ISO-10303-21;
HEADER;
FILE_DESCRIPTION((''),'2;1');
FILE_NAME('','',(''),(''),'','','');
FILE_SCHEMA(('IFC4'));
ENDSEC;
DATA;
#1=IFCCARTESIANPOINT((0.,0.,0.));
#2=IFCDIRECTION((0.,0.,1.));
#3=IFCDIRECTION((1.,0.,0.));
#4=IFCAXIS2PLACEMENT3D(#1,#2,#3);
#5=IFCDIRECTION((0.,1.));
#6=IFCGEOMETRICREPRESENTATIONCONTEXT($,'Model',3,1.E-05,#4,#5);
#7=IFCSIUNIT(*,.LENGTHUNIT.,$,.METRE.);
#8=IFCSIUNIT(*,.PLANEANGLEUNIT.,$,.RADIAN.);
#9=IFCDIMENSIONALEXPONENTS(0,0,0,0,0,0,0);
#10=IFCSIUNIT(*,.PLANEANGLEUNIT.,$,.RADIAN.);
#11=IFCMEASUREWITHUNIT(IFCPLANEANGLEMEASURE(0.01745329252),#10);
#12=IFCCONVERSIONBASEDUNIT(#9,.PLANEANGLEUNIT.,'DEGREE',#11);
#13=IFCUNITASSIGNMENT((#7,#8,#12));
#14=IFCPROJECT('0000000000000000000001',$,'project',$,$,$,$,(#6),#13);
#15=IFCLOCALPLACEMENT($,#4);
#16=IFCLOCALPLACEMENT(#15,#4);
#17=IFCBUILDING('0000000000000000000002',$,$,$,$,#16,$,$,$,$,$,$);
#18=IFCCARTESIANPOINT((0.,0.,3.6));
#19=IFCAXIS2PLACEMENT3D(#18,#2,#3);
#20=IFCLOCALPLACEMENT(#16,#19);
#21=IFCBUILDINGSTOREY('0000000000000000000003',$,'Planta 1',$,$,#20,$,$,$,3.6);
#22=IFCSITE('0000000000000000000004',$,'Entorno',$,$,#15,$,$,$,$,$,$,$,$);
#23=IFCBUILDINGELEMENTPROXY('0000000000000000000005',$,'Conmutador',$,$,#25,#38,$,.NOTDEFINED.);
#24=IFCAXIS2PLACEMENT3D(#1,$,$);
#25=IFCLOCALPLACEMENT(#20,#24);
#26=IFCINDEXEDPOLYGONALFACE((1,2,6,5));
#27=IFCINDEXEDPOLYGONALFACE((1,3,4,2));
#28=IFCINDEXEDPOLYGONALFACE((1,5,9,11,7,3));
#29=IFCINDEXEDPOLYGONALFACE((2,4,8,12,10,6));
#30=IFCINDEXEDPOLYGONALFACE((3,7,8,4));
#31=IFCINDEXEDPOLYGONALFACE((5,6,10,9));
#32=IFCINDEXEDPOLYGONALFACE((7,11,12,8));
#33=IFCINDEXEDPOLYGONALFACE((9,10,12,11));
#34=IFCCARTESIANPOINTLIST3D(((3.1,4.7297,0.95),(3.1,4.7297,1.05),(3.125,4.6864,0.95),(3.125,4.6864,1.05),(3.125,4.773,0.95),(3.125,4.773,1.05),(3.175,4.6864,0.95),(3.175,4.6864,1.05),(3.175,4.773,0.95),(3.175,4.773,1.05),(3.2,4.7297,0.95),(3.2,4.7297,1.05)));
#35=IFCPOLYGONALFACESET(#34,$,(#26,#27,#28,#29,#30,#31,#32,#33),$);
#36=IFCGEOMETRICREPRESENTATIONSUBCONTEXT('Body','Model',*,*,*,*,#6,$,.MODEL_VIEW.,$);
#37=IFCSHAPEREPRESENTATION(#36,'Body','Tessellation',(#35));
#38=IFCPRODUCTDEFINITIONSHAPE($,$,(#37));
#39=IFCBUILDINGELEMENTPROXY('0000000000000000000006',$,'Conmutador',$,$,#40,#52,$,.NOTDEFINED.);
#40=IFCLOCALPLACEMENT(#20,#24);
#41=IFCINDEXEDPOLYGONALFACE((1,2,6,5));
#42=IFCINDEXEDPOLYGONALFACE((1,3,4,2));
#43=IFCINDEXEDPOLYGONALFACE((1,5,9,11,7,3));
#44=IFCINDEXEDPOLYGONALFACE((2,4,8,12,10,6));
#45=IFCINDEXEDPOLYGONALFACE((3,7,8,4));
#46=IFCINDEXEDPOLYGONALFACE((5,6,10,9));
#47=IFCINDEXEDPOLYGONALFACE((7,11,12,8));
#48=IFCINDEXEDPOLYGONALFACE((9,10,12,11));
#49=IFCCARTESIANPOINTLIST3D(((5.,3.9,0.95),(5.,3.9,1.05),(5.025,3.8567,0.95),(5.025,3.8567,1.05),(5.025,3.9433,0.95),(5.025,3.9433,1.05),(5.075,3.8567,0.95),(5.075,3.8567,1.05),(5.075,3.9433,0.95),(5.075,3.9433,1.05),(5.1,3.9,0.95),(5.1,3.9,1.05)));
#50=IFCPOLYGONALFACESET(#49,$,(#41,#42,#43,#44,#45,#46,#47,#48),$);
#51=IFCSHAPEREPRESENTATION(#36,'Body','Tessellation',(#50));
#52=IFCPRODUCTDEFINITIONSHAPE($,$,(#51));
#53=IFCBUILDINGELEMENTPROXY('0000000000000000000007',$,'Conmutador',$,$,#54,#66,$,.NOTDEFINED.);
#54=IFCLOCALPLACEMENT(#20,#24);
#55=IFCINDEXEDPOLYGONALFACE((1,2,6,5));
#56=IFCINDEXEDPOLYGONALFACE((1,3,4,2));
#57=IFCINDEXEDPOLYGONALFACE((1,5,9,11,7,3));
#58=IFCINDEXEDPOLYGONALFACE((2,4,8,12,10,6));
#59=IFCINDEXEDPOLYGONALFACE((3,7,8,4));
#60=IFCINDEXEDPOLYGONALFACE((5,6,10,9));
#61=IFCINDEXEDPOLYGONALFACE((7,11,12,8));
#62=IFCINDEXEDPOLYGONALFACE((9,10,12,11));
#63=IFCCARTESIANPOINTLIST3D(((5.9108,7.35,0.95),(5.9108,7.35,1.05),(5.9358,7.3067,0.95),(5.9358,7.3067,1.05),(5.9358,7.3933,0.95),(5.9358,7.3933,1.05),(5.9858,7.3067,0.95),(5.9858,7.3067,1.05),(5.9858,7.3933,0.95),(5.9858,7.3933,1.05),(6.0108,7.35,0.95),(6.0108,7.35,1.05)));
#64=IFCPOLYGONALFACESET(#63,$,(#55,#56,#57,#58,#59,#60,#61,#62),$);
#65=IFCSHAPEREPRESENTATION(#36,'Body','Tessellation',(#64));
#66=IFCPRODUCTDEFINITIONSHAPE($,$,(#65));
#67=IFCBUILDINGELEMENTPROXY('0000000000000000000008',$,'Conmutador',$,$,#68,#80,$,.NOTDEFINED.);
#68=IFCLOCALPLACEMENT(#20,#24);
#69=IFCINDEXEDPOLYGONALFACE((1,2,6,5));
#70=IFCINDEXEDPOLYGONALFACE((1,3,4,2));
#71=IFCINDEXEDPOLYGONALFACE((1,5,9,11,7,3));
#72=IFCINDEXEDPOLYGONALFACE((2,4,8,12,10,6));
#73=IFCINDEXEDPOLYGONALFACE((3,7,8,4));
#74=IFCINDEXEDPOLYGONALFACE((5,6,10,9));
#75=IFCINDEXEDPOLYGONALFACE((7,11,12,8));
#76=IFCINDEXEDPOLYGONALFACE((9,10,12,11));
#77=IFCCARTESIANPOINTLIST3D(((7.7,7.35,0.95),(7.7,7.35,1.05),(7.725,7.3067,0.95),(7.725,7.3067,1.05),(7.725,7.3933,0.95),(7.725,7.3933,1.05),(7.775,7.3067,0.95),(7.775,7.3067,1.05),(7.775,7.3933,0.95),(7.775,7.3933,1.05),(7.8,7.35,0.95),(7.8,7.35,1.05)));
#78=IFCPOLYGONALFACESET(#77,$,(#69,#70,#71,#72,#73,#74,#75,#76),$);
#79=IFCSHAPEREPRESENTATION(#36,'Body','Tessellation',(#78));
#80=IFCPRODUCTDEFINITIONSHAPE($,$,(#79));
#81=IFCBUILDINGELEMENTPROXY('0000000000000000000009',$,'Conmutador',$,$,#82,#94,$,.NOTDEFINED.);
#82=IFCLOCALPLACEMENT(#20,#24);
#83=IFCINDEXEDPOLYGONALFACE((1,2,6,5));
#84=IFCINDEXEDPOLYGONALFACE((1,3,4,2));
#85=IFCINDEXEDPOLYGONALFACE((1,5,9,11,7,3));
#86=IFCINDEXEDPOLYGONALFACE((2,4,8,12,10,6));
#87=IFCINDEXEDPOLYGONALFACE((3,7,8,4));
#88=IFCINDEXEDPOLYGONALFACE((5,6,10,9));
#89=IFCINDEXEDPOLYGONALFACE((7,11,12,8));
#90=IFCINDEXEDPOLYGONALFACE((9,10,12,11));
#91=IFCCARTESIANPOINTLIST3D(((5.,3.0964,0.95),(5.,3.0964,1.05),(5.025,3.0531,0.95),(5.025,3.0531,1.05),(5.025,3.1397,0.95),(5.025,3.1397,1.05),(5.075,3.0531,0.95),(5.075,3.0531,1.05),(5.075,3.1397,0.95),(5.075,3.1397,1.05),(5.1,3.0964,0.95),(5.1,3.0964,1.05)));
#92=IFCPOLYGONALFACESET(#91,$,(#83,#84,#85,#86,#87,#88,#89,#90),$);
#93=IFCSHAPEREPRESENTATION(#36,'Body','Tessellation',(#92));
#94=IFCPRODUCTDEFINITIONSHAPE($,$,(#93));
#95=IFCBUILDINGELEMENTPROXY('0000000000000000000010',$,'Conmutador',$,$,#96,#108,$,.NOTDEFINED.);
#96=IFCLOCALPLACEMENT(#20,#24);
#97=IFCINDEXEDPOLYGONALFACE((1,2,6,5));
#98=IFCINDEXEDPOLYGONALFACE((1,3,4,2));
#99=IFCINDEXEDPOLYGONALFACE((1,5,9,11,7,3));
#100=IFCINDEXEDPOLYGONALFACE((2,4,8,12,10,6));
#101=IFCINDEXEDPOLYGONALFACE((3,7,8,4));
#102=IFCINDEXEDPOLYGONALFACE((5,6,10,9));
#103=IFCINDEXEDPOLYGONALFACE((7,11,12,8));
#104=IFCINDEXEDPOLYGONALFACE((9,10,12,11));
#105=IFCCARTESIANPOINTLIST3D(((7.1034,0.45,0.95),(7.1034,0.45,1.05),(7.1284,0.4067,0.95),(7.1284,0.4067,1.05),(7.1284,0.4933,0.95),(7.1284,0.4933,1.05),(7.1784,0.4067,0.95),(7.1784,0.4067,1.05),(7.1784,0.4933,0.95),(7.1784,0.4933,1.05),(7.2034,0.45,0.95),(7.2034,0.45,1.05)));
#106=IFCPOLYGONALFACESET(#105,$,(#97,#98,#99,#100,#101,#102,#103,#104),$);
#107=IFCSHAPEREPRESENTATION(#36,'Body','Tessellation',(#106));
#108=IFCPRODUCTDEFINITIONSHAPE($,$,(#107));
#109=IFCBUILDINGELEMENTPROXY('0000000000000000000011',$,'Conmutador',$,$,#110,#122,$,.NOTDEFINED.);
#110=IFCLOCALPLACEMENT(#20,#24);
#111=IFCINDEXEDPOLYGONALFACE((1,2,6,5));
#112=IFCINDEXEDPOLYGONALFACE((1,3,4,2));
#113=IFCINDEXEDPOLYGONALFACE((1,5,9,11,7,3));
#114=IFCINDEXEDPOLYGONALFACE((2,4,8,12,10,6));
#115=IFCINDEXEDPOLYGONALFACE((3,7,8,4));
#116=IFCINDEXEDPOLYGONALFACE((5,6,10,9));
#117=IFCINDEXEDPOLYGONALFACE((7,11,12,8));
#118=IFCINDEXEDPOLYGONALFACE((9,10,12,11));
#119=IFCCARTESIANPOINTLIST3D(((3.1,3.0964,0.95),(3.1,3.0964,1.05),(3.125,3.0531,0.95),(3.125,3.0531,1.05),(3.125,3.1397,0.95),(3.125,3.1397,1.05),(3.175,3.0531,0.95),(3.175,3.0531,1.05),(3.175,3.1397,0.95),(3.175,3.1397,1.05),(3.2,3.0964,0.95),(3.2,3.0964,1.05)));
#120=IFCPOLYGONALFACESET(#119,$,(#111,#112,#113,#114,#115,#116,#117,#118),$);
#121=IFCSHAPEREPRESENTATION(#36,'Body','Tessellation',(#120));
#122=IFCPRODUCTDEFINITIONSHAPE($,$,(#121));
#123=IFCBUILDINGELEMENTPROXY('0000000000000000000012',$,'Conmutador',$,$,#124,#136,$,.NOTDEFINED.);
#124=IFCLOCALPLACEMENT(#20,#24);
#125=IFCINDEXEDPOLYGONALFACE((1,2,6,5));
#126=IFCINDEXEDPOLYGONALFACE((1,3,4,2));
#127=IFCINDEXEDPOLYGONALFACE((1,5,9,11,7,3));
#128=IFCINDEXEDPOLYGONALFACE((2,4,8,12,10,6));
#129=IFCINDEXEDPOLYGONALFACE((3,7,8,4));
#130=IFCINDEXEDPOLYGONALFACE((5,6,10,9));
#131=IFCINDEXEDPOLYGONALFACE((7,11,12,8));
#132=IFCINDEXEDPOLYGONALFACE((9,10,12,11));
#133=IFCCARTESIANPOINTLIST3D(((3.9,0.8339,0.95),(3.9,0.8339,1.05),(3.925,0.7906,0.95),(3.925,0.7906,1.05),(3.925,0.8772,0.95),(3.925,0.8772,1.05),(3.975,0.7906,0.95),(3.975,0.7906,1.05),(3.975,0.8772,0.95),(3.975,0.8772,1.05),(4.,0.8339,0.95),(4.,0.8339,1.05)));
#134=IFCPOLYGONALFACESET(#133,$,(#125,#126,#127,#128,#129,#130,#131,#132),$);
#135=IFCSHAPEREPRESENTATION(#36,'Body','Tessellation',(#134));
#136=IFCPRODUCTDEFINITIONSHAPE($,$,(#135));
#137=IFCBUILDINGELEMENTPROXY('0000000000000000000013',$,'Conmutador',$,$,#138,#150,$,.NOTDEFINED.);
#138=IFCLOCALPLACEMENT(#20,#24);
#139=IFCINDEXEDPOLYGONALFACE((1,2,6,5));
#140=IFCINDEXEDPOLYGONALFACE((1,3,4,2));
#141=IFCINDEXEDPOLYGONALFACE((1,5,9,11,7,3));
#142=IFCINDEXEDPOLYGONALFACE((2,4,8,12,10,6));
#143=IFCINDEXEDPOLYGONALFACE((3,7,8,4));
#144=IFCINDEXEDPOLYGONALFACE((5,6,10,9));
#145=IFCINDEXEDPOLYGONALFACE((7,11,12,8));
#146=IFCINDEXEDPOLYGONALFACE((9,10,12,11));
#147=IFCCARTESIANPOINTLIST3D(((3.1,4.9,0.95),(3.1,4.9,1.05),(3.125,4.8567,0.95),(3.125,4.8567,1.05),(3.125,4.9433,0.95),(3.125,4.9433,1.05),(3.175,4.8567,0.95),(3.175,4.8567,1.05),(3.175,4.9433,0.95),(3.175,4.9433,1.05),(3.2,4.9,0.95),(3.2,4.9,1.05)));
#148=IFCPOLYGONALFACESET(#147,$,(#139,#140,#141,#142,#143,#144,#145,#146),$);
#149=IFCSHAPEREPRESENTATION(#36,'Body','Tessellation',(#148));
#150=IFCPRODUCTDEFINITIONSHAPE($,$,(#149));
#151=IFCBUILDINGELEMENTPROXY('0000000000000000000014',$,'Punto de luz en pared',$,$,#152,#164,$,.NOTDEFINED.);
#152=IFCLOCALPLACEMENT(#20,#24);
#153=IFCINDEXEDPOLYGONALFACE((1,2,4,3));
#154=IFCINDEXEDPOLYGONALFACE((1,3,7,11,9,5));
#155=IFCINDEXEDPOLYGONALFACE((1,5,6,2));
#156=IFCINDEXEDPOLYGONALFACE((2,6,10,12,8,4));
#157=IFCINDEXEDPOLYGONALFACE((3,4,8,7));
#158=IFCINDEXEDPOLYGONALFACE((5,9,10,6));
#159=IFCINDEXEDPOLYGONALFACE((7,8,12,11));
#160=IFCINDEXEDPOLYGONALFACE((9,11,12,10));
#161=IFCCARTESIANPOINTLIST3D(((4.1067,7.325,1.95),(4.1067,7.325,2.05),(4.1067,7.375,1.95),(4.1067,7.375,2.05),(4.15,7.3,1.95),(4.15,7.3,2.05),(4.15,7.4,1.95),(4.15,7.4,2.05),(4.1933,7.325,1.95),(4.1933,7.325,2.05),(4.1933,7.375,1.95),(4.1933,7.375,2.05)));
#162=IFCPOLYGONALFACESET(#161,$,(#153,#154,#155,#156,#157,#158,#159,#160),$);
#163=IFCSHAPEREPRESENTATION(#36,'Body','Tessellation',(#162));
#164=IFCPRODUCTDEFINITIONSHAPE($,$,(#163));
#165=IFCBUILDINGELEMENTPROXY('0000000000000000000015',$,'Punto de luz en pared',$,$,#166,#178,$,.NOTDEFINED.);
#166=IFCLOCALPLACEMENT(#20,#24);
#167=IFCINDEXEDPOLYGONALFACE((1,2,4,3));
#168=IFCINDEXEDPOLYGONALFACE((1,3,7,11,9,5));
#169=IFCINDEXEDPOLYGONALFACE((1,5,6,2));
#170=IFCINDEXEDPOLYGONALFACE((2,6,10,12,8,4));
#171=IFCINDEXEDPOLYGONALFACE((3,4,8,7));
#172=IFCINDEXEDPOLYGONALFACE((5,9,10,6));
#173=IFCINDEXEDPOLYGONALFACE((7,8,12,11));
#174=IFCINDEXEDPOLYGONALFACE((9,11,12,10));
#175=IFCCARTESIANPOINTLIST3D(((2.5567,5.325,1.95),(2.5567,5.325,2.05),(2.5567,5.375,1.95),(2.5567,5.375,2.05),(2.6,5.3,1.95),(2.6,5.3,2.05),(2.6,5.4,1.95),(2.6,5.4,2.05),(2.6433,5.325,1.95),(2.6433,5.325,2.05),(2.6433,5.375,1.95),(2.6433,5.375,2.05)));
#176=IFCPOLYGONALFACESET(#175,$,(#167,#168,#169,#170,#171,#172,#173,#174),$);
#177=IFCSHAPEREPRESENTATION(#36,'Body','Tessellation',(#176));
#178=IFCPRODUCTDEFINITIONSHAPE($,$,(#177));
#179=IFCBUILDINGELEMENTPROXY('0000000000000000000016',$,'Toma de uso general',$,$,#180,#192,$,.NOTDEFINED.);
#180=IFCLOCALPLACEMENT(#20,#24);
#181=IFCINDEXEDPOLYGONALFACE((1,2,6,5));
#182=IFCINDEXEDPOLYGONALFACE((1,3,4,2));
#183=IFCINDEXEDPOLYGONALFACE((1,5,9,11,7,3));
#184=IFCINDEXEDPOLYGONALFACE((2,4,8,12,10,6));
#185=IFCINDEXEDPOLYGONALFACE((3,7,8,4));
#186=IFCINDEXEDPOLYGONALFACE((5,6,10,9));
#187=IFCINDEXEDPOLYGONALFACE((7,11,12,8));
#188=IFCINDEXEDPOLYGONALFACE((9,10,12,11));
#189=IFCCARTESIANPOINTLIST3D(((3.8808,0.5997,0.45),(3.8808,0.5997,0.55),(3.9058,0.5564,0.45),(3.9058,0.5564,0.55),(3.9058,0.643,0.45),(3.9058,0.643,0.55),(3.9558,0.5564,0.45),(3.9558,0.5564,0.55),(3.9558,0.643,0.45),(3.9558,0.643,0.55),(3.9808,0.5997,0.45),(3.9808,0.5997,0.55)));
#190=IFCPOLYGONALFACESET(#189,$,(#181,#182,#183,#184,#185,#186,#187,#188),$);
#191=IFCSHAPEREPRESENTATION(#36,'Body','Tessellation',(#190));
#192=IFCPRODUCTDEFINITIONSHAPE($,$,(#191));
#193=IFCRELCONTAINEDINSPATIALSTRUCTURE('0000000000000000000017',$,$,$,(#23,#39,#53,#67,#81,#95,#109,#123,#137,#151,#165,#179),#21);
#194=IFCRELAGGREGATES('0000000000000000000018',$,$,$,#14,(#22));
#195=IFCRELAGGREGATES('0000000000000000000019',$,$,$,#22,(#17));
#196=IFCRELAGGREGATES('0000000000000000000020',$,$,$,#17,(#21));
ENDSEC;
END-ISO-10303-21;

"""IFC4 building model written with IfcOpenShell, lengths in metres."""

from ifc_helpers import new_model, entity, si_unit, converted_unit, direction, frame, origin_with_axes, place, context, subcontext, project, spatial, polyline, outline, extrude, source, transform, mapped, element, save


model = new_model("IFC4")

# Units and contexts
model_context = context("Model", 3, precision=1e-05, world=origin_with_axes(), true_north=direction((0.0, 1.0)))
body_context = subcontext(model_context, "Body", "Model", "MODEL_VIEW")
ifc_project = project(units=[si_unit("LENGTHUNIT", "METRE"), si_unit("PLANEANGLEUNIT", "RADIAN"), converted_unit("PLANEANGLEUNIT", "DEGREE", entity("IfcPlaneAngleMeasure", 0.01745329252), si_unit("PLANEANGLEUNIT", "RADIAN"), dimensions=[0, 0, 0, 0, 0, 0, 0])], contexts=[model_context])

# Site, building, storey
site_placement = place(None, origin_with_axes())
site = spatial("IfcSite", under=ifc_project, at=site_placement, Name="Entorno")
building_placement = place(site_placement, origin_with_axes())
building = spatial("IfcBuilding", under=site, at=building_placement)
storey_placement = place(building_placement, frame((0.0, 0.0, 3.6), z_axis=(0.0, 0.0, 1.0), x_axis=(1.0, 0.0, 0.0)))
storey = spatial("IfcBuildingStorey", under=building, at=storey_placement, Name="Planta 1", Elevation=3.6)

# Building element proxies
shared_shape_1 = source(origin_with_axes(), body_context, "Body", "SolidModel", [
    extrude(outline(polyline([(0.05, 0.0), (0.025, 0.0433), (-0.025, 0.0433), (-0.05, 0.0), (-0.025, -0.0433), (0.025, -0.0433), (0.05, 0.0)])), frame((0.0, 0.0, -0.05), z_axis=(0.0, 0.0, 1.0), x_axis=(1.0, 0.0, 0.0)), (0.0, 0.0, 1.0), 0.1),
])
proxy_1_placement = place(storey_placement, frame((0.0, 0.0, -3.6), z_axis=(0.0, 0.0, 1.0), x_axis=(1.0, 0.0, 0.0)))
element("IfcBuildingElementProxy", 1, at=proxy_1_placement, inside=storey, Name="Conmutador", PredefinedType="NOTDEFINED", context=body_context, shape_type="Brep", body=[
    mapped(shared_shape_1, transform((3.15, 4.7297, 4.6), x_axis=(1.0, 0.0, 0.0), y_axis=(0.0, 1.0, 0.0), z_axis=(0.0, 0.0, 1.0))),
])
proxy_2_placement = place(storey_placement, frame((0.0, 0.0, -3.6), z_axis=(0.0, 0.0, 1.0), x_axis=(1.0, 0.0, 0.0)))
element("IfcBuildingElementProxy", 2, at=proxy_2_placement, inside=storey, Name="Conmutador", PredefinedType="NOTDEFINED", context=body_context, shape_type="Brep", body=[
    mapped(shared_shape_1, transform((5.05, 3.9, 4.6), x_axis=(1.0, 0.0, 0.0), y_axis=(0.0, 1.0, 0.0), z_axis=(0.0, 0.0, 1.0))),
])
proxy_3_placement = place(storey_placement, frame((0.0, 0.0, -3.6), z_axis=(0.0, 0.0, 1.0), x_axis=(1.0, 0.0, 0.0)))
element("IfcBuildingElementProxy", 3, at=proxy_3_placement, inside=storey, Name="Conmutador", PredefinedType="NOTDEFINED", context=body_context, shape_type="Brep", body=[
    mapped(shared_shape_1, transform((5.9608, 7.35, 4.6), x_axis=(1.0, 0.0, 0.0), y_axis=(0.0, 1.0, 0.0), z_axis=(0.0, 0.0, 1.0))),
])
proxy_4_placement = place(storey_placement, frame((0.0, 0.0, -3.6), z_axis=(0.0, 0.0, 1.0), x_axis=(1.0, 0.0, 0.0)))
element("IfcBuildingElementProxy", 4, at=proxy_4_placement, inside=storey, Name="Conmutador", PredefinedType="NOTDEFINED", context=body_context, shape_type="Brep", body=[
    mapped(shared_shape_1, transform((7.75, 7.35, 4.6), x_axis=(1.0, 0.0, 0.0), y_axis=(0.0, 1.0, 0.0), z_axis=(0.0, 0.0, 1.0))),
])
proxy_5_placement = place(storey_placement, frame((0.0, 0.0, -3.6), z_axis=(0.0, 0.0, 1.0), x_axis=(1.0, 0.0, 0.0)))
element("IfcBuildingElementProxy", 5, at=proxy_5_placement, inside=storey, Name="Conmutador", PredefinedType="NOTDEFINED", context=body_context, shape_type="Brep", body=[
    mapped(shared_shape_1, transform((5.05, 3.0964, 4.6), x_axis=(1.0, 0.0, 0.0), y_axis=(0.0, 1.0, 0.0), z_axis=(0.0, 0.0, 1.0))),
])
proxy_6_placement = place(storey_placement, frame((0.0, 0.0, -3.6), z_axis=(0.0, 0.0, 1.0), x_axis=(1.0, 0.0, 0.0)))
element("IfcBuildingElementProxy", 6, at=proxy_6_placement, inside=storey, Name="Conmutador", PredefinedType="NOTDEFINED", context=body_context, shape_type="Brep", body=[
    mapped(shared_shape_1, transform((7.1534, 0.45, 4.6), x_axis=(1.0, 0.0, 0.0), y_axis=(0.0, 1.0, 0.0), z_axis=(0.0, 0.0, 1.0))),
])
proxy_7_placement = place(storey_placement, frame((0.0, 0.0, -3.6), z_axis=(0.0, 0.0, 1.0), x_axis=(1.0, 0.0, 0.0)))
element("IfcBuildingElementProxy", 7, at=proxy_7_placement, inside=storey, Name="Conmutador", PredefinedType="NOTDEFINED", context=body_context, shape_type="Brep", body=[
    mapped(shared_shape_1, transform((3.15, 3.0964, 4.6), x_axis=(1.0, 0.0, 0.0), y_axis=(0.0, 1.0, 0.0), z_axis=(0.0, 0.0, 1.0))),
])
proxy_8_placement = place(storey_placement, frame((0.0, 0.0, -3.6), z_axis=(0.0, 0.0, 1.0), x_axis=(1.0, 0.0, 0.0)))
element("IfcBuildingElementProxy", 8, at=proxy_8_placement, inside=storey, Name="Conmutador", PredefinedType="NOTDEFINED", context=body_context, shape_type="Brep", body=[
    mapped(shared_shape_1, transform((3.95, 0.8339, 4.6), x_axis=(1.0, 0.0, 0.0), y_axis=(0.0, 1.0, 0.0), z_axis=(0.0, 0.0, 1.0))),
])
proxy_9_placement = place(storey_placement, frame((0.0, 0.0, -3.6), z_axis=(0.0, 0.0, 1.0), x_axis=(1.0, 0.0, 0.0)))
element("IfcBuildingElementProxy", 9, at=proxy_9_placement, inside=storey, Name="Conmutador", PredefinedType="NOTDEFINED", context=body_context, shape_type="Brep", body=[
    mapped(shared_shape_1, transform((3.15, 4.9, 4.6), x_axis=(1.0, 0.0, 0.0), y_axis=(0.0, 1.0, 0.0), z_axis=(0.0, 0.0, 1.0))),
])
shared_shape_2 = source(origin_with_axes(), body_context, "Body", "SolidModel", [
    extrude(outline(polyline([(0.05, 0.0), (0.025, 0.0433), (-0.025, 0.0433), (-0.05, 0.0), (-0.025, -0.0433), (0.025, -0.0433), (0.05, 0.0)])), frame((0.0, 0.0, -0.05), z_axis=(0.0, 0.0, 1.0), x_axis=(1.0, 0.0, 0.0)), (0.0, 0.0, 1.0), 0.1),
])
proxy_10_placement = place(storey_placement, frame((0.0, 0.0, -3.6), z_axis=(0.0, 0.0, 1.0), x_axis=(1.0, 0.0, 0.0)))
element("IfcBuildingElementProxy", 10, at=proxy_10_placement, inside=storey, Name="Punto de luz en pared", PredefinedType="NOTDEFINED", context=body_context, shape_type="Brep", body=[
    mapped(shared_shape_2, transform((4.15, 7.35, 5.6), x_axis=(0.0, -1.0, 0.0), y_axis=(1.0, 0.0, 0.0), z_axis=(0.0, 0.0, 1.0))),
])
proxy_11_placement = place(storey_placement, frame((0.0, 0.0, -3.6), z_axis=(0.0, 0.0, 1.0), x_axis=(1.0, 0.0, 0.0)))
element("IfcBuildingElementProxy", 11, at=proxy_11_placement, inside=storey, Name="Punto de luz en pared", PredefinedType="NOTDEFINED", context=body_context, shape_type="Brep", body=[
    mapped(shared_shape_2, transform((2.6, 5.35, 5.6), x_axis=(0.0, -1.0, 0.0), y_axis=(1.0, 0.0, 0.0), z_axis=(0.0, 0.0, 1.0))),
])
shared_shape_3 = source(origin_with_axes(), body_context, "Body", "SolidModel", [
    extrude(outline(polyline([(0.05, 0.0), (0.025, 0.0433), (-0.025, 0.0433), (-0.05, 0.0), (-0.025, -0.0433), (0.025, -0.0433), (0.05, 0.0)])), frame((0.0, 0.0, -0.05), z_axis=(0.0, 0.0, 1.0), x_axis=(1.0, 0.0, 0.0)), (0.0, 0.0, 1.0), 0.1),
])
proxy_12_placement = place(storey_placement, frame((0.0, 0.0, -3.6), z_axis=(0.0, 0.0, 1.0), x_axis=(1.0, 0.0, 0.0)))
element("IfcBuildingElementProxy", 12, at=proxy_12_placement, inside=storey, Name="Toma de uso general", PredefinedType="NOTDEFINED", context=body_context, shape_type="Brep", body=[
    mapped(shared_shape_3, transform((3.9308, 0.5997, 4.1), x_axis=(-1.0, 0.0, 0.0), y_axis=(0.0, -1.0, 0.0), z_axis=(0.0, 0.0, 1.0))),
])

save(model, "model.ifc")
